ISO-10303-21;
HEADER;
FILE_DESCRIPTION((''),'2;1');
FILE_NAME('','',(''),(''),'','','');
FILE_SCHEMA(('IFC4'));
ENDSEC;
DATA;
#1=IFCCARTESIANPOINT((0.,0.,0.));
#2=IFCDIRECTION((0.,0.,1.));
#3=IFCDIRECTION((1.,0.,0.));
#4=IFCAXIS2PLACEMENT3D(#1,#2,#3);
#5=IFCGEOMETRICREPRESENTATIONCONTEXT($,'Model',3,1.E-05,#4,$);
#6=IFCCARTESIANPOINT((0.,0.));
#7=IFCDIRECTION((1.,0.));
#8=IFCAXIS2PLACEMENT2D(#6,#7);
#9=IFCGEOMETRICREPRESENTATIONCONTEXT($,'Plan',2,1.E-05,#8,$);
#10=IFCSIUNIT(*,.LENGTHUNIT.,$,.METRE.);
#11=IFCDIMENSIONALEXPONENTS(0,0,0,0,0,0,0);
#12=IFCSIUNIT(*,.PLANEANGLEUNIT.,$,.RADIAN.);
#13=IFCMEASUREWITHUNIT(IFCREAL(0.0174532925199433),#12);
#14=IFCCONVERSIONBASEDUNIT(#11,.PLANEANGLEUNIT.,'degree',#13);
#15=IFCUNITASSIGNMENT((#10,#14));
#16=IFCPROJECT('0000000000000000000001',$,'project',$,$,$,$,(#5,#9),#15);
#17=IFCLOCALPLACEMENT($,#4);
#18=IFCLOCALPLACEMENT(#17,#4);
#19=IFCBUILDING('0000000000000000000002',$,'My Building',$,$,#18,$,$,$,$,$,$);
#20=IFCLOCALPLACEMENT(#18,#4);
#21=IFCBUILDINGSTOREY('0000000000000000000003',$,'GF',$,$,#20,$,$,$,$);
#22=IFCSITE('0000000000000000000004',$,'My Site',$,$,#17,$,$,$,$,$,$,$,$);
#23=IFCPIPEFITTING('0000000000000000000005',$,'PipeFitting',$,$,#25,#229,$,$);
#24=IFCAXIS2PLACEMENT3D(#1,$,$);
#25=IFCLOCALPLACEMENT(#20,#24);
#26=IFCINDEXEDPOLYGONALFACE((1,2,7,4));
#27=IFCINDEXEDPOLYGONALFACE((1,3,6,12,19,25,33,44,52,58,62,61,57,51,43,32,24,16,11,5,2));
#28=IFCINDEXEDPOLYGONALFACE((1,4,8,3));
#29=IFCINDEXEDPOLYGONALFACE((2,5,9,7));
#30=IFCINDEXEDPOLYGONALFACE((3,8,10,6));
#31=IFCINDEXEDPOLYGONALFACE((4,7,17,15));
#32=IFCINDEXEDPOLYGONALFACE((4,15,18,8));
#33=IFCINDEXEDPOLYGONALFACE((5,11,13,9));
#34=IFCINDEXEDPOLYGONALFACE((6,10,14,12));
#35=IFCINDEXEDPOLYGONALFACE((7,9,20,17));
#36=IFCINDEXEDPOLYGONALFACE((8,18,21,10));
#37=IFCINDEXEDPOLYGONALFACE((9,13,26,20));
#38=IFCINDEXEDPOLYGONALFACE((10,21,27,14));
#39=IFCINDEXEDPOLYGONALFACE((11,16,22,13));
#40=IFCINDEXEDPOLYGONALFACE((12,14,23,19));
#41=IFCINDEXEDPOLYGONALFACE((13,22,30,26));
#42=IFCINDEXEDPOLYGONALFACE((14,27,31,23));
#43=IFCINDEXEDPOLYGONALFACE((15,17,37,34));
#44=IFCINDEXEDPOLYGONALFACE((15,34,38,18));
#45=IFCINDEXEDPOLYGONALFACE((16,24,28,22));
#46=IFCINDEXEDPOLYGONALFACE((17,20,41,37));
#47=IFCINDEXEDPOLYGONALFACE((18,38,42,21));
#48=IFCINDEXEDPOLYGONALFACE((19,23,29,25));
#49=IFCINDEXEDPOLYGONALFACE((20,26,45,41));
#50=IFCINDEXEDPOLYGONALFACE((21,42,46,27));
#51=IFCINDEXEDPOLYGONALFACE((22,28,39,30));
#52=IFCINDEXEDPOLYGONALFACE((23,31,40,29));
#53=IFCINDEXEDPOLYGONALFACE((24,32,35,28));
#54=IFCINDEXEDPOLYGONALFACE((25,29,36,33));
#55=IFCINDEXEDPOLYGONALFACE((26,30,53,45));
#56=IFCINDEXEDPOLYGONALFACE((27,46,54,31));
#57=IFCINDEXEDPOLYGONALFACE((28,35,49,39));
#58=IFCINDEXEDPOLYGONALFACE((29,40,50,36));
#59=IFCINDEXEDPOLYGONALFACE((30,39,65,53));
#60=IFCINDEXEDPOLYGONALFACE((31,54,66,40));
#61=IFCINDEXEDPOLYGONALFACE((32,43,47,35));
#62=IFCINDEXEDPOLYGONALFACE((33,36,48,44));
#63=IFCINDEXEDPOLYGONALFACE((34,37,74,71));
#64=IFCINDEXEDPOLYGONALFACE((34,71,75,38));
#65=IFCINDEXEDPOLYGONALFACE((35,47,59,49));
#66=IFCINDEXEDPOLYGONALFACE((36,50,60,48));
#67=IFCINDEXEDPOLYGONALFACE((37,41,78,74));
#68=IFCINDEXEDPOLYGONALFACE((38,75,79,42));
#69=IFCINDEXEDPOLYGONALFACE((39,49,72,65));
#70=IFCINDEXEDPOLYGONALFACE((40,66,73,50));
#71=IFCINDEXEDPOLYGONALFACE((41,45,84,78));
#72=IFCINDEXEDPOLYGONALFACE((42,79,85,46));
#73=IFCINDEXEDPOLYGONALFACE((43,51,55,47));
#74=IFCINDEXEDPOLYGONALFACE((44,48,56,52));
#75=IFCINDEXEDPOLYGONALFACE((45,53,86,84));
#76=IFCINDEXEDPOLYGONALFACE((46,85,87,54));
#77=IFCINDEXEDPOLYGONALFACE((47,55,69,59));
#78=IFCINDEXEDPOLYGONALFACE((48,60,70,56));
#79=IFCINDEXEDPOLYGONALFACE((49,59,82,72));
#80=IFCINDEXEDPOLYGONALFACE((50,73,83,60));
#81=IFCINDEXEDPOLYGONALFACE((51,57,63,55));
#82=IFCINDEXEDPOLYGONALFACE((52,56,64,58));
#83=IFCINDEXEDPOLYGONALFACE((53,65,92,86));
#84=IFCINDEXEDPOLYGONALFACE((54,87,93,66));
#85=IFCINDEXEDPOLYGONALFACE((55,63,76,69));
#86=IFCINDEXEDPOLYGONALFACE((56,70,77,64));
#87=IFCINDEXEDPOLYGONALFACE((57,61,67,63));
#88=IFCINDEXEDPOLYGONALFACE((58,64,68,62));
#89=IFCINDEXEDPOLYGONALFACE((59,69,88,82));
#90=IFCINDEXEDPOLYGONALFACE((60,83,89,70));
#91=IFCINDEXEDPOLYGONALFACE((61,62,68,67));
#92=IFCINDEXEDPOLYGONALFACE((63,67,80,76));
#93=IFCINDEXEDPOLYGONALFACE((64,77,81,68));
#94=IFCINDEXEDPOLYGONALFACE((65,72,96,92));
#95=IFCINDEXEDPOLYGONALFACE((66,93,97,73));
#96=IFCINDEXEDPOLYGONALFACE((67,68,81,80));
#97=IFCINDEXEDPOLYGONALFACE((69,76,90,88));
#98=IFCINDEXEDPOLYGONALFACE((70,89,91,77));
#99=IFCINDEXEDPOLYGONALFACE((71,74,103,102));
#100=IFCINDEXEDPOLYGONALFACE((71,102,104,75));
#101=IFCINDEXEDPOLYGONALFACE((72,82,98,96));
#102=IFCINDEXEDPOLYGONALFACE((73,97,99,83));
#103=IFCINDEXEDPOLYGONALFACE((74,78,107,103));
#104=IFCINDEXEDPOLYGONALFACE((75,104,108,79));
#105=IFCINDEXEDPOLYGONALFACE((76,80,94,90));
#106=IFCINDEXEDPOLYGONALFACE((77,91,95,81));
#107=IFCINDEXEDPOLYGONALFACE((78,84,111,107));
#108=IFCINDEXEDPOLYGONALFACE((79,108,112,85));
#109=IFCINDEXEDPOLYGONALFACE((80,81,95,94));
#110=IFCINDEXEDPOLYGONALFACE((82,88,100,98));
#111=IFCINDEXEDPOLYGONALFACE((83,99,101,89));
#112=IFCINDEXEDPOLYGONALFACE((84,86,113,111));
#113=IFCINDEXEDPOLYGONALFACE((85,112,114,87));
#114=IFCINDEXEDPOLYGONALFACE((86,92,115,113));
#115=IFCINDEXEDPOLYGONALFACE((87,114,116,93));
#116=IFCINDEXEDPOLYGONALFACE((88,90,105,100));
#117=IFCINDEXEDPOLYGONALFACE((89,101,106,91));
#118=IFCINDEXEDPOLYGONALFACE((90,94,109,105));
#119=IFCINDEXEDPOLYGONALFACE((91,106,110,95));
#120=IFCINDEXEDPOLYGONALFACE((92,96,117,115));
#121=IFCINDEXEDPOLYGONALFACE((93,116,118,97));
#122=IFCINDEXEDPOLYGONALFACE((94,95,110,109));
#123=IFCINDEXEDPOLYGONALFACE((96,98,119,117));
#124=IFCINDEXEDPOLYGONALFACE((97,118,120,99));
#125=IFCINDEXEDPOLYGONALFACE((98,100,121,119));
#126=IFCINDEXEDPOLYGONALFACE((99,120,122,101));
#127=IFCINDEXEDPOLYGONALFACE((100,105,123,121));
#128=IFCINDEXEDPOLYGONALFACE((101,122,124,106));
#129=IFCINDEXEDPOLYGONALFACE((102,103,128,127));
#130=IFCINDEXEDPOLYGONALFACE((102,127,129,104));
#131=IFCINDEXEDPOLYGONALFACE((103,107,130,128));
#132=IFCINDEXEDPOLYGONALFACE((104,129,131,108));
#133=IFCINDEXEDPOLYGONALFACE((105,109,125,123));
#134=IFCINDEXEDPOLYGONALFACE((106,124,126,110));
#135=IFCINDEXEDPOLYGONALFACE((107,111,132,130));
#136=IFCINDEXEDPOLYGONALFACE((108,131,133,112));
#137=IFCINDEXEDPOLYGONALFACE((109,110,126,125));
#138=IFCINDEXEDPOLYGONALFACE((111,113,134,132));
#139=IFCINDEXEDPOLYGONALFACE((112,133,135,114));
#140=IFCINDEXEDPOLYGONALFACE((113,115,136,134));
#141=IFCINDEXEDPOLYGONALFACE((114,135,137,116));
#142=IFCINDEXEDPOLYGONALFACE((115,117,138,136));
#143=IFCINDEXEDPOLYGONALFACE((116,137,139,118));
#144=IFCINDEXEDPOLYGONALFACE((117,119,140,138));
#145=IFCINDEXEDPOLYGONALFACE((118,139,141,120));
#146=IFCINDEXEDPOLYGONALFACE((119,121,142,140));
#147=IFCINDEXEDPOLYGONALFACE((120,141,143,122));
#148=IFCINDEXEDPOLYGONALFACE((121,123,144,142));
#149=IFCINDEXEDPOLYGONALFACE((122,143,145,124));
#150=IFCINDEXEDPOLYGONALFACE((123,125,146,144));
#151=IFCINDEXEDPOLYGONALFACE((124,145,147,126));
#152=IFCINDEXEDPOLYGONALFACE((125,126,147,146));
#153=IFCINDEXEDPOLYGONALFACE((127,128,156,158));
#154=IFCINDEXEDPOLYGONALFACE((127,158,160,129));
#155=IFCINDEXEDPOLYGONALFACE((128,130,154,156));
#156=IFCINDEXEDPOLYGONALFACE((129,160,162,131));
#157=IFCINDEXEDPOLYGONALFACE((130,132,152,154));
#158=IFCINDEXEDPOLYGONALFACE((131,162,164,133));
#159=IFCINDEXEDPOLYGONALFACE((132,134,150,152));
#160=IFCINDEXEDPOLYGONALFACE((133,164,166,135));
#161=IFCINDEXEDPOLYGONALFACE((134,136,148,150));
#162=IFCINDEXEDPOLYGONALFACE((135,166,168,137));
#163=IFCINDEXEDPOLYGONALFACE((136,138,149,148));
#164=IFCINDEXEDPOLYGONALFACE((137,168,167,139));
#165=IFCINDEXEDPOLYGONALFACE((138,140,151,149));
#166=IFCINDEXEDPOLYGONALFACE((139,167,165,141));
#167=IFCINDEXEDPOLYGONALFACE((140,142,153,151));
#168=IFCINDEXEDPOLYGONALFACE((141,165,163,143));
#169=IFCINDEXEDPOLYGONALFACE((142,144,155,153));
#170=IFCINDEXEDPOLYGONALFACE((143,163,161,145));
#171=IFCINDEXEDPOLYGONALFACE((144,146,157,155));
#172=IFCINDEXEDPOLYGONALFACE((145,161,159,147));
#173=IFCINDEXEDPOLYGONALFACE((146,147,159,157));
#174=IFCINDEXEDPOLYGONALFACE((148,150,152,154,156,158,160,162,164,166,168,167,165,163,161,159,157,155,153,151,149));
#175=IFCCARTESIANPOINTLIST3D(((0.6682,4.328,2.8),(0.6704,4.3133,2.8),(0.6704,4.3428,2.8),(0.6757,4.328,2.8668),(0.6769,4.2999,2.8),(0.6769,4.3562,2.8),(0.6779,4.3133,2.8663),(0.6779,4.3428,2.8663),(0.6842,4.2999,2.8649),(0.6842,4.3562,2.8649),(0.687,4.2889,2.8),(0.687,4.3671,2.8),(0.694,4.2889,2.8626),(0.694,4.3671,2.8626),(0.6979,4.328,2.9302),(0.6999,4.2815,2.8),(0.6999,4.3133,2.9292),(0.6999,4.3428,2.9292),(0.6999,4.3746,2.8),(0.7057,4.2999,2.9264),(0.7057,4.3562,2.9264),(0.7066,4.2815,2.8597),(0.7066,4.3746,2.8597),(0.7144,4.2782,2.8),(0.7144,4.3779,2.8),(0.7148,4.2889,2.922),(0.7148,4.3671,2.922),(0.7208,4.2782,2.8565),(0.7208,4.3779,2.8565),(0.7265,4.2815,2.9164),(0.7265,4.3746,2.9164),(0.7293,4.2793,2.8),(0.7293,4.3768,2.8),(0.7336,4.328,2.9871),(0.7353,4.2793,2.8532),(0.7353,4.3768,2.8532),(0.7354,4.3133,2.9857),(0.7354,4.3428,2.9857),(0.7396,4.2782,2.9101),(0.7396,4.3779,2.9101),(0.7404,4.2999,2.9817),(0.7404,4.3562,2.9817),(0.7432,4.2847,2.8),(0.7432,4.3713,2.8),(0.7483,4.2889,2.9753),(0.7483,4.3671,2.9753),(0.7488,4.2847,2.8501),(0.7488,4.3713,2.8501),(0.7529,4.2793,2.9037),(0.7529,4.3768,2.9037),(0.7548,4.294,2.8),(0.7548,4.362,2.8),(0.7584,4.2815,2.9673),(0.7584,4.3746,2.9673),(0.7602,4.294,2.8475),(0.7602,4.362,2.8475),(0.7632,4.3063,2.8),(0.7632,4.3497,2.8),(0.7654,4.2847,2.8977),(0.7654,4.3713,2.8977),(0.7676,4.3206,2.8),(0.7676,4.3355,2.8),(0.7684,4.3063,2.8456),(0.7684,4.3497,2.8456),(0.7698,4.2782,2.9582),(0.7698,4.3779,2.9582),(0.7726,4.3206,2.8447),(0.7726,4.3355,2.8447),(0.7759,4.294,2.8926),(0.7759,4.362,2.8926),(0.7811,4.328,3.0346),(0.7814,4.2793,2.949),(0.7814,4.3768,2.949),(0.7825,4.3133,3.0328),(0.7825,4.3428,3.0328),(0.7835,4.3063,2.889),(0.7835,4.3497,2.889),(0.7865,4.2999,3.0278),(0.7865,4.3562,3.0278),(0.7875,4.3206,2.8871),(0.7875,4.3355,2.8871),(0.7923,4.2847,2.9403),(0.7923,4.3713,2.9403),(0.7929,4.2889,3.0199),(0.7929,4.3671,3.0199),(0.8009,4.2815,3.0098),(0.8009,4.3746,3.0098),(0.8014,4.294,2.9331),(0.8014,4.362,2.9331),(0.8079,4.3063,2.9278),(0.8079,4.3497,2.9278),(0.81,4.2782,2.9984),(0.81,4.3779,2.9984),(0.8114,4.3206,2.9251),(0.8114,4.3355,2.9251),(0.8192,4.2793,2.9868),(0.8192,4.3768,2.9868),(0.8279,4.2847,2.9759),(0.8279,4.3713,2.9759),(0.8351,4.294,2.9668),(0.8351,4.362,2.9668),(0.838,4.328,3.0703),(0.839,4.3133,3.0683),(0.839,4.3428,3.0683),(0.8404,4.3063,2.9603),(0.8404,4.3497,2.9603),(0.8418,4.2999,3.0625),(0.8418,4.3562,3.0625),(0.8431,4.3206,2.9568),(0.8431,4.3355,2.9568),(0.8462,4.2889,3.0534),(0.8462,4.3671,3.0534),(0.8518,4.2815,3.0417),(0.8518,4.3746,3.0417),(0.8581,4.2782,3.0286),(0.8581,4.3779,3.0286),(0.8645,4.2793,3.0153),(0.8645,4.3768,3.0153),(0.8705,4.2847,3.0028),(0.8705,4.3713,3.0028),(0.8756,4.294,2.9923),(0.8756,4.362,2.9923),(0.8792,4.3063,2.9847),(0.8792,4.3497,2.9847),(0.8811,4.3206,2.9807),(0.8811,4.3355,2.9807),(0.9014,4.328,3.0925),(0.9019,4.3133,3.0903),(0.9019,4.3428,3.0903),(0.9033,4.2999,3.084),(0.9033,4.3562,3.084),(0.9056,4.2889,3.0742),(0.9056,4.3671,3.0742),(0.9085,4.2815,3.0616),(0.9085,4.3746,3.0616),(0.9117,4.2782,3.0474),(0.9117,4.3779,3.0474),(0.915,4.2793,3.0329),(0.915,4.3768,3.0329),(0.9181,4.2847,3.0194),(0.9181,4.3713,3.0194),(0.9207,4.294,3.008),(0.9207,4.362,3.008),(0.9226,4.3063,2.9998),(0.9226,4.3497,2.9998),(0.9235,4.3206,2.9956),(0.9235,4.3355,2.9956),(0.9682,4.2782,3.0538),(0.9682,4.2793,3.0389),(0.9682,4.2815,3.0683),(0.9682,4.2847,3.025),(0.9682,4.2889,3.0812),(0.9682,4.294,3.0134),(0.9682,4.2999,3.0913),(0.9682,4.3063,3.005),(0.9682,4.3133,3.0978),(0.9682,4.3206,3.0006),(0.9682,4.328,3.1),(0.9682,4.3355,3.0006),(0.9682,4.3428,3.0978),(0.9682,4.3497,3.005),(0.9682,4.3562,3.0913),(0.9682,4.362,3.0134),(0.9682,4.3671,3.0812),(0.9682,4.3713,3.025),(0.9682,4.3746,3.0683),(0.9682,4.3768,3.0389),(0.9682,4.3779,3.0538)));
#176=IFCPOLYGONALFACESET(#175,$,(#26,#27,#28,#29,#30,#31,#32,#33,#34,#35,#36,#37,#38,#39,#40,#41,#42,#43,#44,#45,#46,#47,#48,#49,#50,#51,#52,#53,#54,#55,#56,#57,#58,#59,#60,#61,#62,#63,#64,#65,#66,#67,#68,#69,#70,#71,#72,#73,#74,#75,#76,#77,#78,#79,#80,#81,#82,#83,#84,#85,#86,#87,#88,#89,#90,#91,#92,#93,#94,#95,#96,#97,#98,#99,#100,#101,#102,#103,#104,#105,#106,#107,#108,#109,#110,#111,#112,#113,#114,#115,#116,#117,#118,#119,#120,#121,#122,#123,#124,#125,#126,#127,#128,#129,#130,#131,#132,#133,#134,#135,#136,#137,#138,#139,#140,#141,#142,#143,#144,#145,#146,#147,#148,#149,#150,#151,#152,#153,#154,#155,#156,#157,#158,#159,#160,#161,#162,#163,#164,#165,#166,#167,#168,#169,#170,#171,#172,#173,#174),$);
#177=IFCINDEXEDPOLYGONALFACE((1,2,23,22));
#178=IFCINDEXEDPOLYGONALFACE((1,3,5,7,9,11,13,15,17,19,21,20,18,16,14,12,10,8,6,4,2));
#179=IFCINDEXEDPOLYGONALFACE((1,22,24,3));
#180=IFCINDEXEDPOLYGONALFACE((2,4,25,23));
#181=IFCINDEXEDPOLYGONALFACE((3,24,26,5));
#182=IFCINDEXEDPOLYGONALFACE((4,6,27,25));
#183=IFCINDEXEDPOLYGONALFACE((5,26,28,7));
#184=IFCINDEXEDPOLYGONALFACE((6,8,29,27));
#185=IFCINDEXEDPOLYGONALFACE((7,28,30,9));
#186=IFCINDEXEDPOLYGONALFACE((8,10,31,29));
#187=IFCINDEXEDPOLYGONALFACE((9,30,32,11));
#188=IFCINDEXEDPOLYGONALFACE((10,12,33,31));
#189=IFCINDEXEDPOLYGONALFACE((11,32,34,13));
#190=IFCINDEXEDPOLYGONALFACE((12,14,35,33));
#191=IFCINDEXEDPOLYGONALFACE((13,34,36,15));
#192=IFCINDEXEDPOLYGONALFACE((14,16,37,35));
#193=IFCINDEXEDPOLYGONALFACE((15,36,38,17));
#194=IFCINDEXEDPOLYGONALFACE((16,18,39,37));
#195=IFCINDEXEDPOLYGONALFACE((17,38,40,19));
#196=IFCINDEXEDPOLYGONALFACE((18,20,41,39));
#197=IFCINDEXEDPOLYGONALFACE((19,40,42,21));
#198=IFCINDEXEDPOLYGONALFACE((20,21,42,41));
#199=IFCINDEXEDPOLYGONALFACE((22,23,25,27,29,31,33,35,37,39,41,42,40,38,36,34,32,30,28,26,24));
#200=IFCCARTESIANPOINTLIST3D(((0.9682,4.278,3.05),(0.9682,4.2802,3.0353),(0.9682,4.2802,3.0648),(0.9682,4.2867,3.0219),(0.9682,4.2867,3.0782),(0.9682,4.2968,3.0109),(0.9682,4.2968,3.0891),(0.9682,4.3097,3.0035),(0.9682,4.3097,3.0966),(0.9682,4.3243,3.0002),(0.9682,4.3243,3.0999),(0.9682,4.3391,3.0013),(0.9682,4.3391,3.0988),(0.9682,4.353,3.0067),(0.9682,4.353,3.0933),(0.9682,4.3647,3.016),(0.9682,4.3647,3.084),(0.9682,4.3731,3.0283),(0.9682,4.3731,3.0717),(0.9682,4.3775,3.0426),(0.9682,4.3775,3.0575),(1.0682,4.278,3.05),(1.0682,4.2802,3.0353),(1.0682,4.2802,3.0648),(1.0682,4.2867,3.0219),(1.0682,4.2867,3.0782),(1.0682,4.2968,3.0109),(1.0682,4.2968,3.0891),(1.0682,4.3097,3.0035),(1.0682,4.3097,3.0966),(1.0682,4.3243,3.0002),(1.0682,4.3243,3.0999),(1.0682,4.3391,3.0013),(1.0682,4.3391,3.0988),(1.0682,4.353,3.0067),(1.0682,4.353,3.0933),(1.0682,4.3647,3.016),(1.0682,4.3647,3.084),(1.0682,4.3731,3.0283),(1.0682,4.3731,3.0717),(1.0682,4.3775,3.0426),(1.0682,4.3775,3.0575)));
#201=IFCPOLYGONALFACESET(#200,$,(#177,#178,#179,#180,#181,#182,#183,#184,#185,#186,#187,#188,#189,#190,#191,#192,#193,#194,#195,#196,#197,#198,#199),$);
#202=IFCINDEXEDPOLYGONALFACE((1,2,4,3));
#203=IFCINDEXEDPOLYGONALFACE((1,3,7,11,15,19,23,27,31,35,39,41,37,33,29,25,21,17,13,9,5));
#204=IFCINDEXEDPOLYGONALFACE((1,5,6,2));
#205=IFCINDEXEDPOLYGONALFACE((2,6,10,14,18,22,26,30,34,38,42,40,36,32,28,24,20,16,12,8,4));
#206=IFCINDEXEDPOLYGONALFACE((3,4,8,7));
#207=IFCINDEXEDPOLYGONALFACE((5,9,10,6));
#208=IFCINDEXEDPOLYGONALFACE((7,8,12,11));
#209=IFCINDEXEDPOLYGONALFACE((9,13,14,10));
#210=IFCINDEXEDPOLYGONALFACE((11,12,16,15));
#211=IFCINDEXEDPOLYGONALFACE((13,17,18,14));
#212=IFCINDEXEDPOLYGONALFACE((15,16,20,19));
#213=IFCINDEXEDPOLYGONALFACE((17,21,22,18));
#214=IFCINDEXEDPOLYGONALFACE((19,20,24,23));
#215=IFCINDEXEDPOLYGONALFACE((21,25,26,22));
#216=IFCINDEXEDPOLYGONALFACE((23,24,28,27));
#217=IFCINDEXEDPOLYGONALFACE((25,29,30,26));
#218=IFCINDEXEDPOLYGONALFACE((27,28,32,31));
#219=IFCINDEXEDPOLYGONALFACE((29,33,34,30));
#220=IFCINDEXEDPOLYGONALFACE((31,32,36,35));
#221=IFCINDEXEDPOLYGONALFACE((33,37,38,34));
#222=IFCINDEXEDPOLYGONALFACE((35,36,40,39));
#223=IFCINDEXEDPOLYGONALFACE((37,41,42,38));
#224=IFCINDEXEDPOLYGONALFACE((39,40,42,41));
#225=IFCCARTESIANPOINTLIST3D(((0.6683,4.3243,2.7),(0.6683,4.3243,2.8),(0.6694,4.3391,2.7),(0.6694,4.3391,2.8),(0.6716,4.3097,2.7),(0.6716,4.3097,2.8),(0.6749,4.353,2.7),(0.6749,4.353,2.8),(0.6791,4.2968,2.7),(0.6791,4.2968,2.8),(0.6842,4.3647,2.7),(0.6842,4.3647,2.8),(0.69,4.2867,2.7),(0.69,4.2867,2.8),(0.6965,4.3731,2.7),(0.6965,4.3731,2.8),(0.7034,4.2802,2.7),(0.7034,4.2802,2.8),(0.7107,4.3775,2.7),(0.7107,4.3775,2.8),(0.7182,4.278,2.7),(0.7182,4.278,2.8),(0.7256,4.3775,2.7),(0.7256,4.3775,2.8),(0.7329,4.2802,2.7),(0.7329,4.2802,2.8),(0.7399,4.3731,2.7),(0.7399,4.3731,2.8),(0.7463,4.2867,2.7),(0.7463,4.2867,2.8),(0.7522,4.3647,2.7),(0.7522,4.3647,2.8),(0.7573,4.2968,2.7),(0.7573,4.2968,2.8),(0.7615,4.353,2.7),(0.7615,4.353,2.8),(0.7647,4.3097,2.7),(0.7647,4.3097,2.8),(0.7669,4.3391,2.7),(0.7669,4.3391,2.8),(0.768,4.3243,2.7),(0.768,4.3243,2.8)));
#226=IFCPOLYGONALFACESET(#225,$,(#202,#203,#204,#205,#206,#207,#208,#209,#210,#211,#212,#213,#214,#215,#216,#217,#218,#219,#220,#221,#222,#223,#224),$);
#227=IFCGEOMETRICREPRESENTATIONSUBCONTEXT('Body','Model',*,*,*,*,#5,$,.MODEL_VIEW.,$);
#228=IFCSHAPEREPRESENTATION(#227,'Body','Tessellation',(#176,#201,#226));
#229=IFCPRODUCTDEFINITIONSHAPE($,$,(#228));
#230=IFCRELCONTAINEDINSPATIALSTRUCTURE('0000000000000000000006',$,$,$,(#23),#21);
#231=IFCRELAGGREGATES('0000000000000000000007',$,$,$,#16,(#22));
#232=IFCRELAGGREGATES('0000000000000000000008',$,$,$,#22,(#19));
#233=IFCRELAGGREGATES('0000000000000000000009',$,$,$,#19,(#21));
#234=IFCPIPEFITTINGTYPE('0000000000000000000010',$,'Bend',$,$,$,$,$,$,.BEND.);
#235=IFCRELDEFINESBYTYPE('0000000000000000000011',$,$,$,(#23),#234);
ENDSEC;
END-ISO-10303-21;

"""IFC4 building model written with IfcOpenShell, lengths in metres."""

from ifc_helpers import new_model, entity, si_unit, converted_unit, frame, origin_with_axes, origin_2d_with_axis, place, context, subcontext, project, spatial, circle, extrude, source, transform, mapped, type_object, type_shapes, element, save


model = new_model("IFC4")

# Units and contexts
model_context = context("Model", 3, precision=1e-05, world=origin_with_axes())
plan_context = context("Plan", 2, precision=1e-05, world=origin_2d_with_axis())
body_context_1 = subcontext(model_context, "Body", "Model", "MODEL_VIEW")
ifc_project = project(units=[si_unit("LENGTHUNIT", "METRE"), converted_unit("PLANEANGLEUNIT", "degree", entity("IfcReal", 0.0174532925199433), si_unit("PLANEANGLEUNIT", "RADIAN"), dimensions=[0, 0, 0, 0, 0, 0, 0])], contexts=[model_context, plan_context])

# Site, building, storey
site_placement = place(None, origin_with_axes())
site = spatial("IfcSite", under=ifc_project, at=site_placement, Name="My Site")
building_placement = place(site_placement, origin_with_axes())
building = spatial("IfcBuilding", under=site, at=building_placement, Name="My Building")
storey_placement = place(building_placement, origin_with_axes())
storey = spatial("IfcBuildingStorey", under=building, at=storey_placement, Name="GF")

# Pipe fitting
pipe_fitting_type = type_object("IfcPipeFittingType", Name="Bend", PredefinedType="BEND")
shared_shape_1 = source(origin_with_axes(), body_context_1, "Body", "SolidModel", [
    entity("IfcSweptDiskSolid", entity("IfcIndexedPolyCurve", entity("IfcCartesianPointList3D", [[0.0, 0.0, 0.1], [0.0, -0.0732, 0.2768], [0.0, -0.25, 0.35]]), [entity("IfcArcIndex", [1, 2, 3])]), 0.05),
    extrude(circle(Radius=0.05), origin_with_axes(), (0.0, 0.0, 1.0), 0.1),
    extrude(circle(Radius=0.05), frame((0.0, -0.25, 0.35), z_axis=(0.0, -1.0, 0.0), x_axis=(1.0, 0.0, 0.0)), (0.0, 0.0, 1.0), 0.1),
])
type_shapes(pipe_fitting_type, [shared_shape_1])
for number, where, z_axis, x_axis, name in (
    (1, (1.0682, 4.328, 3.05), (-1.0, 0.0, 0.0), (0.0, -1.0, 0.0), "PipeFitting"),
):
    element("IfcPipeFitting", number, at=place(storey_placement, frame(where, z_axis=z_axis, x_axis=x_axis)), inside=storey, type_object=pipe_fitting_type, Name=name, context=body_context_1, shape_type="MappedRepresentation", body=[
        mapped(shared_shape_1, transform((0.0, 0.0, 0.0), x_axis=(1.0, 0.0, 0.0), y_axis=(0.0, 1.0, 0.0), z_axis=(0.0, 0.0, 1.0), scale=1.0)),
    ])

save(model, "model.ifc")
